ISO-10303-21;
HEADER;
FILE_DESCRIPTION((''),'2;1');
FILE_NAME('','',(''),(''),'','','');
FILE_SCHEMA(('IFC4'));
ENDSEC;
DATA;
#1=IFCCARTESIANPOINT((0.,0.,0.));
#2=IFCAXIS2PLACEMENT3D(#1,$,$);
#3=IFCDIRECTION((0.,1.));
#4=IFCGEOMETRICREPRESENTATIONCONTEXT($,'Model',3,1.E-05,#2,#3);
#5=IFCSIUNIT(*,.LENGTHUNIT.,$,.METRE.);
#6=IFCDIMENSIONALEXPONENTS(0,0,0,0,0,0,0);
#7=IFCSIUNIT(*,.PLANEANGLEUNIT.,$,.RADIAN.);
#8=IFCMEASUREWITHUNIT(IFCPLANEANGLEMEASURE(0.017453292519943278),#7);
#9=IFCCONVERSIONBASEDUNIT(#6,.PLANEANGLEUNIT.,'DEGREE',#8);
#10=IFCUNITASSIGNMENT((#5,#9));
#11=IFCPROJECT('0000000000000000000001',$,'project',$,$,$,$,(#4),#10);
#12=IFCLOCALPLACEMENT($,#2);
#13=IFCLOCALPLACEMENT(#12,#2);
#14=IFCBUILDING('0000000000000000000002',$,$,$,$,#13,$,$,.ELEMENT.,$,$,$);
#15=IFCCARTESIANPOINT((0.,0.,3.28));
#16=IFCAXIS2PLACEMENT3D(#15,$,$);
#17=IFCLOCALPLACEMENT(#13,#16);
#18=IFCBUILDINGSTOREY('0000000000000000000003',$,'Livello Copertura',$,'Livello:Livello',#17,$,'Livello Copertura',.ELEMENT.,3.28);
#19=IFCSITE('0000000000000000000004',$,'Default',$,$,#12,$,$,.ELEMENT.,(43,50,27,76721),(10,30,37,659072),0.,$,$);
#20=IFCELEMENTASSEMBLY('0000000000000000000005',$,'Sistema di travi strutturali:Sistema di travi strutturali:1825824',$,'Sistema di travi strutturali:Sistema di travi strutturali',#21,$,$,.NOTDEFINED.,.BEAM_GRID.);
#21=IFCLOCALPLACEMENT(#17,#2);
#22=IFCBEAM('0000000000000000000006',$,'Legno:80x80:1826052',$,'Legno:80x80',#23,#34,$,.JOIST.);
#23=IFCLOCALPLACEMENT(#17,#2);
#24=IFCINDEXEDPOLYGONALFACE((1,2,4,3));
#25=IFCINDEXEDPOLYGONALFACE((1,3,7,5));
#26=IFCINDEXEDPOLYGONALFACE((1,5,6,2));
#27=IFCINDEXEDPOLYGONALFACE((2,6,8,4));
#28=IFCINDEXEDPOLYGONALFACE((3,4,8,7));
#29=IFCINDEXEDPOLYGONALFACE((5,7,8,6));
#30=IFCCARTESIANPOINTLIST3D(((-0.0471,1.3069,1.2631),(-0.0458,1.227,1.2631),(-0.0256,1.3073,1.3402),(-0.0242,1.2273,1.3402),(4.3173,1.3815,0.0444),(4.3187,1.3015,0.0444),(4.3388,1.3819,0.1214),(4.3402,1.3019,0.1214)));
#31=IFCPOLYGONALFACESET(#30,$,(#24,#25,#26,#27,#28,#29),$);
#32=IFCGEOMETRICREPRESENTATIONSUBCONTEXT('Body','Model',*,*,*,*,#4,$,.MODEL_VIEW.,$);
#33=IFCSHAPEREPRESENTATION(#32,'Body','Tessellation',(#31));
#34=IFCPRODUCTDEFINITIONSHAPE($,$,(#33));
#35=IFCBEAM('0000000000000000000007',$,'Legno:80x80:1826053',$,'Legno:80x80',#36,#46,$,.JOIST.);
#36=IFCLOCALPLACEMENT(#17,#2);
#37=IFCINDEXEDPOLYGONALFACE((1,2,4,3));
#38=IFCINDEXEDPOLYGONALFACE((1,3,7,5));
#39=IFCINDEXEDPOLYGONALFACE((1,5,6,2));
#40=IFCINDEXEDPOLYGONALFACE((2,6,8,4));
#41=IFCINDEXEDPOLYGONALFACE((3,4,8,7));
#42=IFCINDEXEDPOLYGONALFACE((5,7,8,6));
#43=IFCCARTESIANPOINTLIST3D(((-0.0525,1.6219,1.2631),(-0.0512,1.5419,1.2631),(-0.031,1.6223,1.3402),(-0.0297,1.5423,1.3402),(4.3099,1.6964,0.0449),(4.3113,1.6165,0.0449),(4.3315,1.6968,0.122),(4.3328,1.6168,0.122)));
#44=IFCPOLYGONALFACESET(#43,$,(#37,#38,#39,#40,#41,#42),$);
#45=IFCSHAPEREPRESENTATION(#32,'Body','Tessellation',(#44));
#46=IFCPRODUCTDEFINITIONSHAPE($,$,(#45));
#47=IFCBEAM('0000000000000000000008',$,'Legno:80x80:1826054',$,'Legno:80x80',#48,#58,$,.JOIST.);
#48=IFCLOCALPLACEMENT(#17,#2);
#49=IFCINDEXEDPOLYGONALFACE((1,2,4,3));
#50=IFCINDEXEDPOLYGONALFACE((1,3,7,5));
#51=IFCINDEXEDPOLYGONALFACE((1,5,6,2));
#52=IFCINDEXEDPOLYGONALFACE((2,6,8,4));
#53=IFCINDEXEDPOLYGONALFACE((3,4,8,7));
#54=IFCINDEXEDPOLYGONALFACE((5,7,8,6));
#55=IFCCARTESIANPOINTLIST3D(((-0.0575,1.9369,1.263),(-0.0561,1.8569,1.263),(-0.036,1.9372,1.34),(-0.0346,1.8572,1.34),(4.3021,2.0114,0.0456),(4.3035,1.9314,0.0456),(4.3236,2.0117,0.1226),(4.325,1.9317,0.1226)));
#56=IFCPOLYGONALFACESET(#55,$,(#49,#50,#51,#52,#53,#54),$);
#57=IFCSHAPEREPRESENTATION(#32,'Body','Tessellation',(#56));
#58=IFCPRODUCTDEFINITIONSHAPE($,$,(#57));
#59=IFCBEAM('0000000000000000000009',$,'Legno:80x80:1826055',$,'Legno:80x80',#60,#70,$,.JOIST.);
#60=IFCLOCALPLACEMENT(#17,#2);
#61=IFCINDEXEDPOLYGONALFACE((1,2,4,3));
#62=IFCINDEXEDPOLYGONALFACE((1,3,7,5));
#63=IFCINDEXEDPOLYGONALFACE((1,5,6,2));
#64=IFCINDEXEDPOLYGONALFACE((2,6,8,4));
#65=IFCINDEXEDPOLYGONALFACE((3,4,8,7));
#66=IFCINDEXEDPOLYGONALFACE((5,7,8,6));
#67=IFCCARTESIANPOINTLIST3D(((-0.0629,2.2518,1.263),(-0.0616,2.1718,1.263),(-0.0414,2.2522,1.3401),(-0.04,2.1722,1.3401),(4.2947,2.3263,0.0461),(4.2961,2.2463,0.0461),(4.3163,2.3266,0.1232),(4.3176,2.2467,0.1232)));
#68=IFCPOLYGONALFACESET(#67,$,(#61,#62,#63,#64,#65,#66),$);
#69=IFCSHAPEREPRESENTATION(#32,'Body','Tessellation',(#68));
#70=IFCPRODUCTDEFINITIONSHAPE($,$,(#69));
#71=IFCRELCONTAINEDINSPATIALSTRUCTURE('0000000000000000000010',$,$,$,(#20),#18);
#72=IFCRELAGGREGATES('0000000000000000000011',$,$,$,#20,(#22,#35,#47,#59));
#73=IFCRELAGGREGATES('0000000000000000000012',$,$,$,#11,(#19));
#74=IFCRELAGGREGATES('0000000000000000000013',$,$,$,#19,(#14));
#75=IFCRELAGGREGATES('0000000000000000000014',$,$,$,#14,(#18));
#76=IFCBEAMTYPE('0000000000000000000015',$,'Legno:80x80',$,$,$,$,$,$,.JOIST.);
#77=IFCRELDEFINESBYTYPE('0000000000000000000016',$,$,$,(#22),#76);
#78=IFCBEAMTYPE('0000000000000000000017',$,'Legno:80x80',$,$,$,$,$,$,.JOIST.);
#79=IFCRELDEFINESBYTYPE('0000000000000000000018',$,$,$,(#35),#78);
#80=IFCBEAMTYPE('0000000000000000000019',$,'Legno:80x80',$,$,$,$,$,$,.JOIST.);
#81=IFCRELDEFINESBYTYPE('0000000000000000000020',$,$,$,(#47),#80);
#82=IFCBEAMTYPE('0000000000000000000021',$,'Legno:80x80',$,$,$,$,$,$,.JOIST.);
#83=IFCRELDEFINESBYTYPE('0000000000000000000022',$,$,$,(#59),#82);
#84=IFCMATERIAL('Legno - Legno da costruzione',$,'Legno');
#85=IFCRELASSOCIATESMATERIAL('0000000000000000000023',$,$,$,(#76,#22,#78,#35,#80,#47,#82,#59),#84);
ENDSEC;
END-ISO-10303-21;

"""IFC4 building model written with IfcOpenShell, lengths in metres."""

from ifc_helpers import new_model, entity, si_unit, converted_unit, direction, frame, origin, place, context, subcontext, project, spatial, indexed_curve, outline, extrude, source, transform, mapped, material, type_object, type_shapes, element, aggregate, save


model = new_model("IFC4")

# Units and contexts
model_context = context("Model", 3, precision=1e-05, world=origin(), true_north=direction((0.0, 1.0)))
body_context = subcontext(model_context, "Body", "Model", "MODEL_VIEW")
ifc_project = project(units=[si_unit("LENGTHUNIT", "METRE"), converted_unit("PLANEANGLEUNIT", "DEGREE", entity("IfcPlaneAngleMeasure", 0.017453292519943278), si_unit("PLANEANGLEUNIT", "RADIAN"), dimensions=[0, 0, 0, 0, 0, 0, 0])], contexts=[model_context])

# Site, building, storey
site_placement = place(None, origin())
site = spatial("IfcSite", under=ifc_project, at=site_placement, Name="Default", CompositionType="ELEMENT", RefLatitude=(43, 50, 27, 76721), RefLongitude=(10, 30, 37, 659072), RefElevation=0.0)
building_placement = place(site_placement, origin())
building = spatial("IfcBuilding", under=site, at=building_placement, CompositionType="ELEMENT")
storey_placement = place(building_placement, frame((0.0, 0.0, 3.28)))
storey = spatial("IfcBuildingStorey", under=building, at=storey_placement, Name="Livello Copertura", ObjectType="Livello:Livello", LongName="Livello Copertura", CompositionType="ELEMENT", Elevation=3.28)

# Shared definitions
ifc_material = material(Name="Legno - Legno da costruzione", Category="Legno")

# Element assembly, beams
assembly_1_placement = place(storey_placement, origin())
assembly_1 = element("IfcElementAssembly", 1, at=assembly_1_placement, inside=storey, Name="Sistema di travi strutturali:Sistema di travi strutturali:1825824", ObjectType="Sistema di travi strutturali:Sistema di travi strutturali", AssemblyPlace="NOTDEFINED", PredefinedType="BEAM_GRID")
beam_type_1 = type_object("IfcBeamType", Name="Legno:80x80", PredefinedType="JOIST", material=ifc_material)
shared_shape_1 = source(origin(), body_context, "Body", "SweptSolid", [
    extrude(outline(indexed_curve([(-2.266, -0.04), (2.266, -0.04), (2.266, 0.04), (-2.266, 0.04), (-2.266, -0.04)], self_intersect=False)), frame((0.0, 0.0, -0.04), z_axis=(0.0, 0.0, 1.0), x_axis=(-1.0, 0.0, 0.0)), (0.0, 0.0, 1.0), 0.08),
])
type_shapes(beam_type_1, [shared_shape_1])
beam_1_placement = place(assembly_1_placement, frame((2.1465, 1.3044, 0.6923), z_axis=(0.268881, 0.004594, 0.963163), x_axis=(-0.963022, -0.016456, 0.26892)))
beam_1 = element("IfcBeam", 2, at=beam_1_placement, type_object=beam_type_1, material=ifc_material, Name="Legno:80x80:1826052", ObjectType="Legno:80x80", PredefinedType="JOIST", context=body_context, shape_type="MappedRepresentation", body=[
    mapped(shared_shape_1, transform((0.0, 0.0, 0.0), scale=1.0)),
])
beam_type_2 = type_object("IfcBeamType", Name="Legno:80x80", PredefinedType="JOIST", material=ifc_material)
shared_shape_2 = source(origin(), body_context, "Body", "SweptSolid", [
    extrude(outline(indexed_curve([(-2.265, -0.04), (2.265, -0.04), (2.265, 0.04), (-2.265, 0.04), (-2.265, -0.04)], self_intersect=False)), frame((0.0, 0.0, -0.04), z_axis=(0.0, 0.0, 1.0), x_axis=(-1.0, 0.0, 0.0)), (0.0, 0.0, 1.0), 0.08),
])
type_shapes(beam_type_2, [shared_shape_2])
beam_2_placement = place(assembly_1_placement, frame((2.1401, 1.6194, 0.6925), z_axis=(0.268881, 0.004594, 0.963163), x_axis=(-0.963022, -0.016456, 0.26892)))
beam_2 = element("IfcBeam", 3, at=beam_2_placement, type_object=beam_type_2, material=ifc_material, Name="Legno:80x80:1826053", ObjectType="Legno:80x80", PredefinedType="JOIST", context=body_context, shape_type="MappedRepresentation", body=[
    mapped(shared_shape_2, transform((0.0, 0.0, 0.0), scale=1.0)),
])
beam_type_3 = type_object("IfcBeamType", Name="Legno:80x80", PredefinedType="JOIST", material=ifc_material)
shared_shape_3 = source(origin(), body_context, "Body", "SweptSolid", [
    extrude(outline(indexed_curve([(-2.2635, -0.04), (2.2635, -0.04), (2.2635, 0.04), (-2.2635, 0.04), (-2.2635, -0.04)], self_intersect=False)), frame((0.0, 0.0, -0.04), z_axis=(0.0, 0.0, 1.0), x_axis=(-1.0, 0.0, 0.0)), (0.0, 0.0, 1.0), 0.08),
])
type_shapes(beam_type_3, [shared_shape_3])
beam_3_placement = place(assembly_1_placement, frame((2.1337, 1.9343, 0.6928), z_axis=(0.268881, 0.004594, 0.963163), x_axis=(-0.963022, -0.016456, 0.26892)))
beam_3 = element("IfcBeam", 4, at=beam_3_placement, type_object=beam_type_3, material=ifc_material, Name="Legno:80x80:1826054", ObjectType="Legno:80x80", PredefinedType="JOIST", context=body_context, shape_type="MappedRepresentation", body=[
    mapped(shared_shape_3, transform((0.0, 0.0, 0.0), scale=1.0)),
])
beam_type_4 = type_object("IfcBeamType", Name="Legno:80x80", PredefinedType="JOIST", material=ifc_material)
shared_shape_4 = source(origin(), body_context, "Body", "SweptSolid", [
    extrude(outline(indexed_curve([(-2.2625, -0.04), (2.2625, -0.04), (2.2625, 0.04), (-2.2625, 0.04), (-2.2625, -0.04)], self_intersect=False)), frame((0.0, 0.0, -0.04), z_axis=(0.0, 0.0, 1.0), x_axis=(-1.0, 0.0, 0.0)), (0.0, 0.0, 1.0), 0.08),
])
type_shapes(beam_type_4, [shared_shape_4])
beam_4_placement = place(assembly_1_placement, frame((2.1273, 2.2492, 0.6931), z_axis=(0.268881, 0.004594, 0.963163), x_axis=(-0.963022, -0.016456, 0.26892)))
beam_4 = element("IfcBeam", 5, at=beam_4_placement, type_object=beam_type_4, material=ifc_material, Name="Legno:80x80:1826055", ObjectType="Legno:80x80", PredefinedType="JOIST", context=body_context, shape_type="MappedRepresentation", body=[
    mapped(shared_shape_4, transform((0.0, 0.0, 0.0), scale=1.0)),
])
aggregate(assembly_1, [beam_1, beam_2, beam_3, beam_4])

save(model, "model.ifc")
